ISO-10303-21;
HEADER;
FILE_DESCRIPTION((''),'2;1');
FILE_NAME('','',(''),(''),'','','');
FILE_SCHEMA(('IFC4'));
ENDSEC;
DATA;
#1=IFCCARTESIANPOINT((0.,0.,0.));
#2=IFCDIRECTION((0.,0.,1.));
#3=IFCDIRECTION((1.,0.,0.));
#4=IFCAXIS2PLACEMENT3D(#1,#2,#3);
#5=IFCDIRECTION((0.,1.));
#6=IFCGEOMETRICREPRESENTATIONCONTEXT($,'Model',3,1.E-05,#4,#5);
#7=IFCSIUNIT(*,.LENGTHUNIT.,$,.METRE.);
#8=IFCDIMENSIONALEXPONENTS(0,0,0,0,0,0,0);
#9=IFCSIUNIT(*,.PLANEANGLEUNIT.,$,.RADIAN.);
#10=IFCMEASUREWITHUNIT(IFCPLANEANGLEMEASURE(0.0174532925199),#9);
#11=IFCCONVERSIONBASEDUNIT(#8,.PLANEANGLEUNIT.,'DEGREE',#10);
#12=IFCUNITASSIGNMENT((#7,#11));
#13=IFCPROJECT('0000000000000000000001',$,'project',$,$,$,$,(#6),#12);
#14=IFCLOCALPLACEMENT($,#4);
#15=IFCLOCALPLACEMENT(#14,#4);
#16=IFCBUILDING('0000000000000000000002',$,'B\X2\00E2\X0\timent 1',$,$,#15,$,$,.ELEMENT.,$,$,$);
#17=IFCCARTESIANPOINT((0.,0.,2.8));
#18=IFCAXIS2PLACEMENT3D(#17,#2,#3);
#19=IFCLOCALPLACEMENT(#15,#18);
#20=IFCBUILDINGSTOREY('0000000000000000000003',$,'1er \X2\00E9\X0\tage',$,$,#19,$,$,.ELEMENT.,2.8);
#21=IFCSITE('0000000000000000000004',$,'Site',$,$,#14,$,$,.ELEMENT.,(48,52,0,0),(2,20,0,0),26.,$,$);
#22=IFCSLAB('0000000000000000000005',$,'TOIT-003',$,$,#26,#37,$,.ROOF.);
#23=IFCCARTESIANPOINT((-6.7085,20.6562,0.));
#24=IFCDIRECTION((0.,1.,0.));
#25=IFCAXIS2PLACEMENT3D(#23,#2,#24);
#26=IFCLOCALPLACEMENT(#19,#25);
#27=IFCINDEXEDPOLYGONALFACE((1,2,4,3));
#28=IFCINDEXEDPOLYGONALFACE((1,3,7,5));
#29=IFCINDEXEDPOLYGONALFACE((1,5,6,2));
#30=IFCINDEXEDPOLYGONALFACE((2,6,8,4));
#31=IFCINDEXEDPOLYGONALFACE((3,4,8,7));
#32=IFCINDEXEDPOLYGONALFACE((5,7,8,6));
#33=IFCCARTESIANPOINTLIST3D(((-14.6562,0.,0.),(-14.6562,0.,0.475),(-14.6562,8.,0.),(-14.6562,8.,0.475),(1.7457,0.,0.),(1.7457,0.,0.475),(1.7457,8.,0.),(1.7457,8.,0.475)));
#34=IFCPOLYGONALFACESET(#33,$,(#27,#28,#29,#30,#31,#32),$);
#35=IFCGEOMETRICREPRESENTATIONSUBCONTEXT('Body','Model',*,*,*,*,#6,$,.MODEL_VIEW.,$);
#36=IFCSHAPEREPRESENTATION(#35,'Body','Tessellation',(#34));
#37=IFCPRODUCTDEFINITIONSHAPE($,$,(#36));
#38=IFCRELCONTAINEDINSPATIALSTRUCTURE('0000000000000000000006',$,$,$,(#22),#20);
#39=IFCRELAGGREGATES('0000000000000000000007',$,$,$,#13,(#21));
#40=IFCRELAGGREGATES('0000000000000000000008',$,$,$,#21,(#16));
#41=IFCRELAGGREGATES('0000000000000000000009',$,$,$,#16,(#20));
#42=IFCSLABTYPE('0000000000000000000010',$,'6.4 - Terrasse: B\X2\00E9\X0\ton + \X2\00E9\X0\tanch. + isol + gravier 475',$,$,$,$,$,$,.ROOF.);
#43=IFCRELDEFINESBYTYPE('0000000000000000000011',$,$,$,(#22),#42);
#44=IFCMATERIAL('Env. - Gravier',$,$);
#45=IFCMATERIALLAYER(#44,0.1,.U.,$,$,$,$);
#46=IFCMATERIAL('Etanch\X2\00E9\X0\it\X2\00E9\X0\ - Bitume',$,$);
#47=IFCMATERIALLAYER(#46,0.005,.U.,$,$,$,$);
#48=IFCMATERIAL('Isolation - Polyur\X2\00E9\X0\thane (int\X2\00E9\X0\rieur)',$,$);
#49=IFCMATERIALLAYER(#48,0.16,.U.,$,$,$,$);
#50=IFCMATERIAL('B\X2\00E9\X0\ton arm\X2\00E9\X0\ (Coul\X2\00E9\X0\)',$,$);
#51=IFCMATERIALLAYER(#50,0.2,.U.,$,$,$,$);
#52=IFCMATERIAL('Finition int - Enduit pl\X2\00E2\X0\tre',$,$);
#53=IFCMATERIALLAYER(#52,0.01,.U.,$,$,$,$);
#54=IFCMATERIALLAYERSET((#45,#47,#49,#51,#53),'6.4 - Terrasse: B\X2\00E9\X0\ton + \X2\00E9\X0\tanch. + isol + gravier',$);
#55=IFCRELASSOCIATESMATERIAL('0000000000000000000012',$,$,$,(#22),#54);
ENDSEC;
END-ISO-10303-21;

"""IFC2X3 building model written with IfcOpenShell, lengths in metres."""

from ifc_helpers import new_model, entity, si_unit, converted_unit, direction, frame, origin_with_axes, place, context, subcontext, project, spatial, polyline, outline, extrude, material, layer, layer_set, layer_usage, type_object, element, save


model = new_model("IFC2X3")

# Units and contexts
model_context = context("Model", 3, precision=1e-05, world=origin_with_axes(), true_north=direction((0.0, 1.0)))
body_context = subcontext(model_context, "Body", "Model", "MODEL_VIEW")
ifc_project = project(units=[si_unit("LENGTHUNIT", "METRE"), converted_unit("PLANEANGLEUNIT", "DEGREE", entity("IfcPlaneAngleMeasure", 0.0174532925199), si_unit("PLANEANGLEUNIT", "RADIAN"), dimensions=[0, 0, 0, 0, 0, 0, 0])], contexts=[model_context])

# Site, building, storey
site_placement = place(None, origin_with_axes())
site = spatial("IfcSite", under=ifc_project, at=site_placement, Name="Site", CompositionType="ELEMENT", RefLatitude=(48, 52, 0, 0), RefLongitude=(2, 20, 0, 0), RefElevation=26.0)
building_placement = place(site_placement, origin_with_axes())
building = spatial("IfcBuilding", under=site, at=building_placement, Name="Bâtiment 1", CompositionType="ELEMENT")
storey_placement = place(building_placement, frame((0.0, 0.0, 2.8), z_axis=(0.0, 0.0, 1.0), x_axis=(1.0, 0.0, 0.0)))
storey = spatial("IfcBuildingStorey", under=building, at=storey_placement, Name="1er étage", CompositionType="ELEMENT", Elevation=2.8)

# Slab
ifc_material_1 = material(Name="Env. - Gravier")
ifc_layer_1 = layer(ifc_material_1, 0.1, ventilated="UNKNOWN")
ifc_material_2 = material(Name="Etanchéité - Bitume")
ifc_layer_2 = layer(ifc_material_2, 0.005, ventilated="UNKNOWN")
ifc_material_3 = material(Name="Isolation - Polyuréthane (intérieur)")
ifc_layer_3 = layer(ifc_material_3, 0.16, ventilated="UNKNOWN")
ifc_material_4 = material(Name="Béton armé (Coulé)")
ifc_layer_4 = layer(ifc_material_4, 0.2, ventilated="UNKNOWN")
ifc_material_5 = material(Name="Finition int - Enduit plâtre")
ifc_layer_5 = layer(ifc_material_5, 0.01, ventilated="UNKNOWN")
ifc_layer_set_1 = layer_set([ifc_layer_1, ifc_layer_2, ifc_layer_3, ifc_layer_4, ifc_layer_5], Name="6.4 - Terrasse: Béton + étanch. + isol + gravier")
ifc_layer_usage_1 = layer_usage(ifc_layer_set_1, "AXIS3", "NEGATIVE", 0.475)
slab_type_1 = type_object("IfcSlabType", Name="6.4 - Terrasse: Béton + étanch. + isol + gravier 475", PredefinedType="ROOF")
slab_1_placement = place(storey_placement, frame((-6.7085, 20.6562, 0.0), z_axis=(0.0, 0.0, 1.0), x_axis=(0.0, 1.0, 0.0)))
element("IfcSlab", 1, at=slab_1_placement, inside=storey, type_object=slab_type_1, material=ifc_layer_usage_1, Name="TOIT-003", PredefinedType="ROOF", context=body_context, shape_type="SweptSolid", body=[
    extrude(outline(polyline([(1.7457, 0.0), (1.7457, 8.0), (-14.6562, 8.0), (-14.6562, 0.0), (1.7457, 0.0)])), origin_with_axes(), (0.0, 0.0, 1.0), 0.475),
])

save(model, "model.ifc")
